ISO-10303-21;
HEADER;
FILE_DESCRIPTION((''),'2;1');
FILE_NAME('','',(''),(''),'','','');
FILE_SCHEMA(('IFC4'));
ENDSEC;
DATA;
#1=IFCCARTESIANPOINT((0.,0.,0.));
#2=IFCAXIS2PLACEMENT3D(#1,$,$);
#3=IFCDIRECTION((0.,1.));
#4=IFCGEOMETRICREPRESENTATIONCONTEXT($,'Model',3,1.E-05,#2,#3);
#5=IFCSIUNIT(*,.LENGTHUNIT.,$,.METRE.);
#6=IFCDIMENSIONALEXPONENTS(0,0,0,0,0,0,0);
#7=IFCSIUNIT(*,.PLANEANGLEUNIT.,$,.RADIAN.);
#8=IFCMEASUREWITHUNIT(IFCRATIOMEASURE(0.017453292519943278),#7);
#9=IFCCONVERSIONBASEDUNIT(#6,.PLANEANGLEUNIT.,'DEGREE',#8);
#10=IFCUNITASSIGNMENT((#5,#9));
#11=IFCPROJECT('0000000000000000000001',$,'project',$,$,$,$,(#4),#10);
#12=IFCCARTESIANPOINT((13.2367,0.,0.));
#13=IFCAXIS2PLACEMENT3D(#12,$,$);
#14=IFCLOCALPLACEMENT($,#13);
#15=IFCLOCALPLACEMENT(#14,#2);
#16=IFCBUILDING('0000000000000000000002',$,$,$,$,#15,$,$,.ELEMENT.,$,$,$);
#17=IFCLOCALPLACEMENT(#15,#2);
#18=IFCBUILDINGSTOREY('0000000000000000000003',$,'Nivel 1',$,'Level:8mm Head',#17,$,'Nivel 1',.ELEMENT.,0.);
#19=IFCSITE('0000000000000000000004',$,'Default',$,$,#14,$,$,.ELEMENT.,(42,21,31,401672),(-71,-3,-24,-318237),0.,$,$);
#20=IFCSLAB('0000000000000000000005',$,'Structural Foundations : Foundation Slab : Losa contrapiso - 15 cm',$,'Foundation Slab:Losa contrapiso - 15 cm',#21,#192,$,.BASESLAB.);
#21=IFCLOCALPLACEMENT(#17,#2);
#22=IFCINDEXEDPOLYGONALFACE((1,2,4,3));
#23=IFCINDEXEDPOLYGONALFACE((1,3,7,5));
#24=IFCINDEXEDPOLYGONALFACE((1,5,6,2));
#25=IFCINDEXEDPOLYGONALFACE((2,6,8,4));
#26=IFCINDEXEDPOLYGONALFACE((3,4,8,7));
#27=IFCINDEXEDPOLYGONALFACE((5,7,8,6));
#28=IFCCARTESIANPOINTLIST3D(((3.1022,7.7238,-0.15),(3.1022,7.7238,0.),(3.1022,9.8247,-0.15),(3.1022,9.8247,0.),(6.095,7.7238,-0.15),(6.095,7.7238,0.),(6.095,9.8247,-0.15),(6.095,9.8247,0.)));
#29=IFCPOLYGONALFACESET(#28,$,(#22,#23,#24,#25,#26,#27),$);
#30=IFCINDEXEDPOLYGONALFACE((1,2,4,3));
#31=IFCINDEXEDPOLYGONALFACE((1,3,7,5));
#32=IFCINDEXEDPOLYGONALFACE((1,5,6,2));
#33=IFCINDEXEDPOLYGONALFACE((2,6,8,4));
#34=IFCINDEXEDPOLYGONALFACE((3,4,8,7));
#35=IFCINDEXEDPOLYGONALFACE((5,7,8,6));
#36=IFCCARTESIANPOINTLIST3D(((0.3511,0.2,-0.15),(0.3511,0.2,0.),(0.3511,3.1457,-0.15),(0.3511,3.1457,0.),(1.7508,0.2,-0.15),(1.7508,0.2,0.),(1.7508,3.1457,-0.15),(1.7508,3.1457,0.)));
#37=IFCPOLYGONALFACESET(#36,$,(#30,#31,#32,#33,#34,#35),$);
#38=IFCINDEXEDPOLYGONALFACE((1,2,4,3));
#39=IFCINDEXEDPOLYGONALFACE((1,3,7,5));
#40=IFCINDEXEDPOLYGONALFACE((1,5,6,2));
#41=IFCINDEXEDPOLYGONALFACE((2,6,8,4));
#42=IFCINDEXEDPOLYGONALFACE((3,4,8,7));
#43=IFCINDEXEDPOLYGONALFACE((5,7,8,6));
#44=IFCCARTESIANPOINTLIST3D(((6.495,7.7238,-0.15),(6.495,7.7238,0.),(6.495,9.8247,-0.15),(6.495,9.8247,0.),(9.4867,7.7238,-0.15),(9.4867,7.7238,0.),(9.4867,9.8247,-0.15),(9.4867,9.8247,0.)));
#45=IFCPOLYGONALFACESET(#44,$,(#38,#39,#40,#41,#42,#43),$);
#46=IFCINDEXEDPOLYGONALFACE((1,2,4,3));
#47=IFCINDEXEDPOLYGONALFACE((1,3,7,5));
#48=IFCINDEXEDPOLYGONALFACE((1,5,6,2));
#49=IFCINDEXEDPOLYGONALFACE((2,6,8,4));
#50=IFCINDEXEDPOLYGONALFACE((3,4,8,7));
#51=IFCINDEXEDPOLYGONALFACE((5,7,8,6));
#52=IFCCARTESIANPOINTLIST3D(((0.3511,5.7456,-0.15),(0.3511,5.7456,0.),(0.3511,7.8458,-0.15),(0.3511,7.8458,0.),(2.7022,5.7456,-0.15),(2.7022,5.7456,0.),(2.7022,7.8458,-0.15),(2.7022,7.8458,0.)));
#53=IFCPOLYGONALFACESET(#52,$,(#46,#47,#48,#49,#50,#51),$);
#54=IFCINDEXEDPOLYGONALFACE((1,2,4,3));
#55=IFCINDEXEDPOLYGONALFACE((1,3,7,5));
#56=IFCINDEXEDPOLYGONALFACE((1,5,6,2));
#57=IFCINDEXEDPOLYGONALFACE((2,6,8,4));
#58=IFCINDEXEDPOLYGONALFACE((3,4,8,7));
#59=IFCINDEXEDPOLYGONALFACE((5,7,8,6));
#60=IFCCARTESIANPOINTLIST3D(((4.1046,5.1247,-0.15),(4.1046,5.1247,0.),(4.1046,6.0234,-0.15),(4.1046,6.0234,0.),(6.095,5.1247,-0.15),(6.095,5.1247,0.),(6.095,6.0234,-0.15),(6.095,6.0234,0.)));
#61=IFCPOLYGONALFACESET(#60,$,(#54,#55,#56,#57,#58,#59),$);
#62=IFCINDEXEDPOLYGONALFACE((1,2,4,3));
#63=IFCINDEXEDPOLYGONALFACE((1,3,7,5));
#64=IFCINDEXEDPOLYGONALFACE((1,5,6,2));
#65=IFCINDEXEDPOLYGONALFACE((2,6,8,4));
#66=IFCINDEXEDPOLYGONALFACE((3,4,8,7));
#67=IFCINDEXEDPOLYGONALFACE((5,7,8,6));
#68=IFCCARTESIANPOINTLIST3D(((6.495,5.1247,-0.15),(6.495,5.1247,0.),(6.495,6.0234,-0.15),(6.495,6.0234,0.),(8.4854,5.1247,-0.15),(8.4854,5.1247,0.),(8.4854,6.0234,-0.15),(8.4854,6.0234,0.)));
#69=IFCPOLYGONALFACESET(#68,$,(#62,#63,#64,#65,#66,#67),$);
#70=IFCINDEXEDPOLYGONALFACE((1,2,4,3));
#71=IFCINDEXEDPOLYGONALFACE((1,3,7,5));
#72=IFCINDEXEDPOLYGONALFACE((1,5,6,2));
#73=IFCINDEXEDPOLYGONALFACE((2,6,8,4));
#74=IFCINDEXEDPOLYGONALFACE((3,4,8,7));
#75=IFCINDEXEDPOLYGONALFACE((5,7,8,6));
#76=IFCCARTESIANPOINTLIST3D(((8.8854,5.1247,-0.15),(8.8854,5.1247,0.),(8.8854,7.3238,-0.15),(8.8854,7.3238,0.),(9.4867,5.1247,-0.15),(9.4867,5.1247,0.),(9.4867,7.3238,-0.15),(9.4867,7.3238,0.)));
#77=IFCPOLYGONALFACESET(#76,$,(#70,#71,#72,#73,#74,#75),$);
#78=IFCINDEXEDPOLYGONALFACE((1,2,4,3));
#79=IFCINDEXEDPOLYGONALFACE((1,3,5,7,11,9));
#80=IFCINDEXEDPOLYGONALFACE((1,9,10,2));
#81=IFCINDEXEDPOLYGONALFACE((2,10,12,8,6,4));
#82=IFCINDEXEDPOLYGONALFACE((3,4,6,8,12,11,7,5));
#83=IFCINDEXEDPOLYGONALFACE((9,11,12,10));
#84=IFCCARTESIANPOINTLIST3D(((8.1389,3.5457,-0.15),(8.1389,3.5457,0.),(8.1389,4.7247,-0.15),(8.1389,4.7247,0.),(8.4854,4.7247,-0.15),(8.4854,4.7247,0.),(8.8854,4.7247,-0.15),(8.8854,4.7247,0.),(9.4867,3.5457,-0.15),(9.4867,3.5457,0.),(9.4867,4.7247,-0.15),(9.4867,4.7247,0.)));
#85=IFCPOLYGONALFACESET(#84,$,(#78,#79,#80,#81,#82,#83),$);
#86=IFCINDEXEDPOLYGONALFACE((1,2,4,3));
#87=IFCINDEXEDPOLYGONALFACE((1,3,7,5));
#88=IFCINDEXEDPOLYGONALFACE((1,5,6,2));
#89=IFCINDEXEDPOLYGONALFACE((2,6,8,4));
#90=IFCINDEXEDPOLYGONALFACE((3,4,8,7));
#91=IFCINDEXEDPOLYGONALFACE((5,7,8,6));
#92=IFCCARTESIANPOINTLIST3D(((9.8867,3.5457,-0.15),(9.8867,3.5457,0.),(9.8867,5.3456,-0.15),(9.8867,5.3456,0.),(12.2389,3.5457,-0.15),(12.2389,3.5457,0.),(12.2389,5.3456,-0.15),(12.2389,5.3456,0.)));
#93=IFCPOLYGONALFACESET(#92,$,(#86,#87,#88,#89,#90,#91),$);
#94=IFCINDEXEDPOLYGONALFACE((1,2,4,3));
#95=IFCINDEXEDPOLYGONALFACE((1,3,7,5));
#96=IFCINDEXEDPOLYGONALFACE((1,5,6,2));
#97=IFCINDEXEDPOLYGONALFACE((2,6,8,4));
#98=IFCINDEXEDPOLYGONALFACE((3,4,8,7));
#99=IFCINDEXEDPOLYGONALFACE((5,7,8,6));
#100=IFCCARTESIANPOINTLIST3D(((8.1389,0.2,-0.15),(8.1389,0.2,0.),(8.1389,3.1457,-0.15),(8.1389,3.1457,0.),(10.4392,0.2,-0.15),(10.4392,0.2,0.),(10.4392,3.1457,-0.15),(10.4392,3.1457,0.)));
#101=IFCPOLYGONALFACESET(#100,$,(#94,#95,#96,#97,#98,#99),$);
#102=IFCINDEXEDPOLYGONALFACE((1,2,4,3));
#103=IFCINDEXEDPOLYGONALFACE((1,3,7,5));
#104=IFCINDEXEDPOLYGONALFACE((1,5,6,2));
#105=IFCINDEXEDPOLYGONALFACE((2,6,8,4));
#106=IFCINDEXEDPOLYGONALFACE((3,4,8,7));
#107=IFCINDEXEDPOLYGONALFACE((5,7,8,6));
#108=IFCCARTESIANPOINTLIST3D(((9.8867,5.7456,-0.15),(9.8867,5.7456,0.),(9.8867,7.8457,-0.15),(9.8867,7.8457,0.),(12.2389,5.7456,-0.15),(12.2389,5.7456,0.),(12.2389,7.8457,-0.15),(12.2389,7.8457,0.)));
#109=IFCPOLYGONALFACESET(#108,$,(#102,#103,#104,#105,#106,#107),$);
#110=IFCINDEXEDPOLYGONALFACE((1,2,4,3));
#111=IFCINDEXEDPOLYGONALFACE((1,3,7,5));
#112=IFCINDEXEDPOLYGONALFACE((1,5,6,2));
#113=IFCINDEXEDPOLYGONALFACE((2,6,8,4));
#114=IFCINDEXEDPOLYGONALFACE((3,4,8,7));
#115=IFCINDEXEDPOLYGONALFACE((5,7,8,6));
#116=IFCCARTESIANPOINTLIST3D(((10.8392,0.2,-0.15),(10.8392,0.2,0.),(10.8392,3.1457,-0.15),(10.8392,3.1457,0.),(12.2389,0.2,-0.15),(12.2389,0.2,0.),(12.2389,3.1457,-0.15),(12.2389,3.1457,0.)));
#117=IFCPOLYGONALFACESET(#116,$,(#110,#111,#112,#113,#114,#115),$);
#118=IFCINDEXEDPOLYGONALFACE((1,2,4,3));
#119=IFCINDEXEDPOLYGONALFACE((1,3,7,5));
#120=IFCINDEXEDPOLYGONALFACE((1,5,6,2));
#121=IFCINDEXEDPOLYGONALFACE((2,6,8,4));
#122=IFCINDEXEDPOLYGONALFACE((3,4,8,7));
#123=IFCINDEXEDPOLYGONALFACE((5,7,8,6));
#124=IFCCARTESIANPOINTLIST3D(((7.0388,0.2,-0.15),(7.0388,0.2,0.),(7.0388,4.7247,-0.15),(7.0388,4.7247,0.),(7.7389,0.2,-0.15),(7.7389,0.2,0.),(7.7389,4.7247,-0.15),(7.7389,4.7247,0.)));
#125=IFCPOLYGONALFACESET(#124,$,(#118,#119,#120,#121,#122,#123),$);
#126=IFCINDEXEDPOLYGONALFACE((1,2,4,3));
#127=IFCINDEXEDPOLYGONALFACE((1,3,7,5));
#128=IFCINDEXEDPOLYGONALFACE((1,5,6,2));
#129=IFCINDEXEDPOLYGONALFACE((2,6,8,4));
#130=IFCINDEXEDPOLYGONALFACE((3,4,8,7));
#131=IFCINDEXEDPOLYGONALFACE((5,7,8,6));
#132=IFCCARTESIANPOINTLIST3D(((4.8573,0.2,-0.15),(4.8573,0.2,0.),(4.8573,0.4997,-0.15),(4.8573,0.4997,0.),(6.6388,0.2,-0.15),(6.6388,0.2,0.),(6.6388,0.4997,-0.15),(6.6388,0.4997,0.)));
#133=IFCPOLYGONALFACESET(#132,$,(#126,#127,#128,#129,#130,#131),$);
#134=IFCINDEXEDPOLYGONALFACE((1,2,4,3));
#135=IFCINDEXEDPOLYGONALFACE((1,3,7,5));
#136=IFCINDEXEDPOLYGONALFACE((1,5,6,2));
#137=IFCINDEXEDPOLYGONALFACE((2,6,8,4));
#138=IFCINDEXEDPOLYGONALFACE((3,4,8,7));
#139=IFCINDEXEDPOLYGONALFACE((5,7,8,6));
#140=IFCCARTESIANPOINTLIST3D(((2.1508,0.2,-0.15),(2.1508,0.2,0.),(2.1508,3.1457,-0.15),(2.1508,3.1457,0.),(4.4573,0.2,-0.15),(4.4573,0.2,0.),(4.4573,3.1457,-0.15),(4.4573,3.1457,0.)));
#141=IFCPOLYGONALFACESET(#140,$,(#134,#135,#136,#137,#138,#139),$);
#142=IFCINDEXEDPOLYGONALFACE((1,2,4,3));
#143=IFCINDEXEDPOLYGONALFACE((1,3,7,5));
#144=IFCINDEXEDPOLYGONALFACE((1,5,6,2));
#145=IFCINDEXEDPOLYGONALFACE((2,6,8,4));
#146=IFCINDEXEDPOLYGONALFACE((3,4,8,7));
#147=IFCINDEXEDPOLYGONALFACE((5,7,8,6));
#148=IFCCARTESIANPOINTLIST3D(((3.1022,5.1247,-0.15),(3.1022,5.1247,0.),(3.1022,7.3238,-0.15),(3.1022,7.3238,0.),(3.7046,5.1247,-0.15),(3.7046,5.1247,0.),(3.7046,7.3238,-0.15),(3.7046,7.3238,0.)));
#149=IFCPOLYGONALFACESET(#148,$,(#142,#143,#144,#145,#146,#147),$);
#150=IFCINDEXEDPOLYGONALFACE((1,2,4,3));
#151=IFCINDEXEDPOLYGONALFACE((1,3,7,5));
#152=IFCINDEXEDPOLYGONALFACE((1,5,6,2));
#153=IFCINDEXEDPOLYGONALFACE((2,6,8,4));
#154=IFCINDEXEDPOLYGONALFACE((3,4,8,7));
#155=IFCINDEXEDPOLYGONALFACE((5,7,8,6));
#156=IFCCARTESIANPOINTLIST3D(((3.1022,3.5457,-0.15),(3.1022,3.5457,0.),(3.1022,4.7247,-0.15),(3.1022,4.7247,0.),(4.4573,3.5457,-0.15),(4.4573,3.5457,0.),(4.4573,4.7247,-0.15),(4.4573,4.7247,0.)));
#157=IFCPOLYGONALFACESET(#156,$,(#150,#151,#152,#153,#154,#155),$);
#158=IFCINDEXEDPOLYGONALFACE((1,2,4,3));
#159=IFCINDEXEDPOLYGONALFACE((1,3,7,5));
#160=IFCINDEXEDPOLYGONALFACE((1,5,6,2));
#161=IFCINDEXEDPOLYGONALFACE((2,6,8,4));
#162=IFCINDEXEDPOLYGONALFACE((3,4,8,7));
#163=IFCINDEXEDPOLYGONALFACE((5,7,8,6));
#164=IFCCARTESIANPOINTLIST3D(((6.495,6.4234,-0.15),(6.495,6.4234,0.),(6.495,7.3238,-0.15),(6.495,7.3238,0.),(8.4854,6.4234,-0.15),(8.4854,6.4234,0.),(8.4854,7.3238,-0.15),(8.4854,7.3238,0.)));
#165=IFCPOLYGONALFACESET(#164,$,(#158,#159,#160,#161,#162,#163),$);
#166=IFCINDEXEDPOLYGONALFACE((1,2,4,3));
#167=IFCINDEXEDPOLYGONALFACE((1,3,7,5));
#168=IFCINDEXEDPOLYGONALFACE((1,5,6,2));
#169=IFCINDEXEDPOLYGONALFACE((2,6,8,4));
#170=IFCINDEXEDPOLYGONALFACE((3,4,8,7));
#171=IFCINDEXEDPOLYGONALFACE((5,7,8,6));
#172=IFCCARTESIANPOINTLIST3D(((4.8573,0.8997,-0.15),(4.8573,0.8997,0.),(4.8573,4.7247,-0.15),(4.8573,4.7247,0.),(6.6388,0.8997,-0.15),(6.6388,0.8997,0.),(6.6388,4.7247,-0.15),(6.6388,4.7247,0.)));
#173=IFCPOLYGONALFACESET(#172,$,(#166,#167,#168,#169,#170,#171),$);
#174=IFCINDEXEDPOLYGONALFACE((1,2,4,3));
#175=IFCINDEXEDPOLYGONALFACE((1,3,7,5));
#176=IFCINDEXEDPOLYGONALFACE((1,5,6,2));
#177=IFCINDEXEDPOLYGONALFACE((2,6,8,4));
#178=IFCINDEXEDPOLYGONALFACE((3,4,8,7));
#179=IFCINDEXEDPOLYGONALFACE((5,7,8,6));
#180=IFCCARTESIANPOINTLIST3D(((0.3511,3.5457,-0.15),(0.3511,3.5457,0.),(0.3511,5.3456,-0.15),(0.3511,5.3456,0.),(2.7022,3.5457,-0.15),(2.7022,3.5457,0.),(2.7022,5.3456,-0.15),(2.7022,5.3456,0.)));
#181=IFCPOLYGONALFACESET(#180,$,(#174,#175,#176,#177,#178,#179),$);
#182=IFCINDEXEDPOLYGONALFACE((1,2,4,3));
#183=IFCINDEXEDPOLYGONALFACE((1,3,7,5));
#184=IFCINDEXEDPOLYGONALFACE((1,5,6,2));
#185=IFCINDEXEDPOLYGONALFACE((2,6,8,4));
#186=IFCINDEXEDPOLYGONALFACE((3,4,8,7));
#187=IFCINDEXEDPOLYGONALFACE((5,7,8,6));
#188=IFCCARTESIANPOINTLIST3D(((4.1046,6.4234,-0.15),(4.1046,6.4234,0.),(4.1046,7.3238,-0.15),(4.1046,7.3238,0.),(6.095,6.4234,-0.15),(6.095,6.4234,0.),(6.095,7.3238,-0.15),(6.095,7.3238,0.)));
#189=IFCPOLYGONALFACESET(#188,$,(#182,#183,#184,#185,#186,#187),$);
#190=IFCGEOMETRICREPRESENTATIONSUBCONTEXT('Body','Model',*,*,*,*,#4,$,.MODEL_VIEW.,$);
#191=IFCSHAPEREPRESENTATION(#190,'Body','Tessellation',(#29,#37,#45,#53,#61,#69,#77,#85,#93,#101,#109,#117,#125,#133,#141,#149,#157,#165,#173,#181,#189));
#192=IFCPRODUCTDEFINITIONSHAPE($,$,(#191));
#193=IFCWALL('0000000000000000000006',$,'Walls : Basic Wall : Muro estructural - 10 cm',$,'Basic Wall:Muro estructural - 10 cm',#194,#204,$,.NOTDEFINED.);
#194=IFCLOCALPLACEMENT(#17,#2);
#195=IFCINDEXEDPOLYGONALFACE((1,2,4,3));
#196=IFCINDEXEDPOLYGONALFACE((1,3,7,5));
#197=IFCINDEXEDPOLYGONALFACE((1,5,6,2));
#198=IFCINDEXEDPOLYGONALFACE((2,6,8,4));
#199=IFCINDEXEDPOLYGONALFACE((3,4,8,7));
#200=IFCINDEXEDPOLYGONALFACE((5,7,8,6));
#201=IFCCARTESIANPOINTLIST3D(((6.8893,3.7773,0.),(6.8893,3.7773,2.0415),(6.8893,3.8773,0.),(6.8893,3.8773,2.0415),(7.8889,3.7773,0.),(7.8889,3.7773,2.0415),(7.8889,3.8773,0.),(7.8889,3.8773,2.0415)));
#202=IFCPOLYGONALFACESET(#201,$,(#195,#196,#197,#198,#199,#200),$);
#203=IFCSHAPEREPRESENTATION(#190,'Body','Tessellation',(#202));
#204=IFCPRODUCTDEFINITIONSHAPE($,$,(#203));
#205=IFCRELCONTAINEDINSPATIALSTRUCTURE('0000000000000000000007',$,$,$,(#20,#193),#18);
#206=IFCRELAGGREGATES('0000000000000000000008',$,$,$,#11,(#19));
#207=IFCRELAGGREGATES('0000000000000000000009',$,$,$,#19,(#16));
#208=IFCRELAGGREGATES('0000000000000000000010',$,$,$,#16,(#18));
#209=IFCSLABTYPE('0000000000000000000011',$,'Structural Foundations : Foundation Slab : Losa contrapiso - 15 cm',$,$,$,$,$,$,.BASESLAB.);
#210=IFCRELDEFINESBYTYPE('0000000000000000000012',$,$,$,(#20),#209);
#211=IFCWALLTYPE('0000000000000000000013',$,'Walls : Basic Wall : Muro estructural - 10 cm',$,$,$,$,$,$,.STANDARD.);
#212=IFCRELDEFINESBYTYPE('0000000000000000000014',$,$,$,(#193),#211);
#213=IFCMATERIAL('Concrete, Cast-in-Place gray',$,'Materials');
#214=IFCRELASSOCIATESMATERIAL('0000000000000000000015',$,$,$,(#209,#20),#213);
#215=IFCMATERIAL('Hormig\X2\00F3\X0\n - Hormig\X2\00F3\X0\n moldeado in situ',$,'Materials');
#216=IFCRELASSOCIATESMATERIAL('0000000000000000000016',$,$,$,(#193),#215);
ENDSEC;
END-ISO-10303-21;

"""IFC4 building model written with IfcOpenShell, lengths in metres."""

from ifc_helpers import new_model, entity, si_unit, converted_unit, direction, frame, origin, place, context, subcontext, project, spatial, indexed_curve, outline, extrude, material, type_object, element, save


model = new_model("IFC4")

# Units and contexts
model_context = context("Model", 3, precision=1e-05, world=origin(), true_north=direction((0.0, 1.0)))
body_context = subcontext(model_context, "Body", "Model", "MODEL_VIEW")
ifc_project = project(units=[si_unit("LENGTHUNIT", "METRE"), converted_unit("PLANEANGLEUNIT", "DEGREE", entity("IfcRatioMeasure", 0.017453292519943278), si_unit("PLANEANGLEUNIT", "RADIAN"), dimensions=[0, 0, 0, 0, 0, 0, 0])], contexts=[model_context])

# Site, building, storey
site_placement = place(None, frame((13.2367, 0.0, 0.0)))
site = spatial("IfcSite", under=ifc_project, at=site_placement, Name="Default", CompositionType="ELEMENT", RefLatitude=(42, 21, 31, 401672), RefLongitude=(-71, -3, -24, -318237), RefElevation=0.0)
building_placement = place(site_placement, origin())
building = spatial("IfcBuilding", under=site, at=building_placement, CompositionType="ELEMENT")
storey_placement = place(building_placement, origin())
storey = spatial("IfcBuildingStorey", under=building, at=storey_placement, Name="Nivel 1", ObjectType="Level:8mm Head", LongName="Nivel 1", CompositionType="ELEMENT", Elevation=0.0)

# Slab
ifc_material_1 = material(Name="Concrete, Cast-in-Place gray", Category="Materials")
slab_type = type_object("IfcSlabType", Name="Structural Foundations : Foundation Slab : Losa contrapiso - 15 cm", PredefinedType="BASESLAB", material=ifc_material_1)
slab_placement = place(storey_placement, origin())
element("IfcSlab", 1, at=slab_placement, inside=storey, type_object=slab_type, material=ifc_material_1, Name="Structural Foundations : Foundation Slab : Losa contrapiso - 15 cm", ObjectType="Foundation Slab:Losa contrapiso - 15 cm", PredefinedType="BASESLAB", context=body_context, shape_type="SweptSolid", body=[
    extrude(outline(indexed_curve([(-1.0505, -1.4964), (1.0505, -1.4964), (1.0505, 1.4964), (-1.0505, 1.4964), (-1.0505, -1.4964)], self_intersect=False)), frame((4.5986, 8.7743, -0.15), z_axis=(0.0, 0.0, 1.0), x_axis=(0.0, -1.0, 0.0)), (0.0, 0.0, 1.0), 0.15),
    extrude(outline(indexed_curve([(-0.6998, -1.4729), (0.6998, -1.4729), (0.6998, 1.4729), (-0.6998, 1.4729), (-0.6998, -1.4729)], self_intersect=False)), frame((1.051, 1.6729, -0.15), z_axis=(0.0, 0.0, 1.0), x_axis=(-1.0, 0.0, 0.0)), (0.0, 0.0, 1.0), 0.15),
    extrude(outline(indexed_curve([(-1.4958, -1.0505), (1.4958, -1.0505), (1.4958, 1.0505), (-1.4958, 1.0505), (-1.4958, -1.0505)], self_intersect=False)), frame((7.9908, 8.7743, -0.15)), (0.0, 0.0, 1.0), 0.15),
    extrude(outline(indexed_curve([(-1.1755, -1.0501), (1.1755, -1.0501), (1.1755, 1.0501), (-1.1755, 1.0501), (-1.1755, -1.0501)], self_intersect=False)), frame((1.5266, 6.7957, -0.15), z_axis=(0.0, 0.0, 1.0), x_axis=(-1.0, 0.0, 0.0)), (0.0, 0.0, 1.0), 0.15),
    extrude(outline(indexed_curve([(-0.4493, -0.9952), (0.4493, -0.9952), (0.4493, 0.9952), (-0.4493, 0.9952), (-0.4493, -0.9952)], self_intersect=False)), frame((5.0998, 5.574, -0.15), z_axis=(0.0, 0.0, 1.0), x_axis=(0.0, 1.0, 0.0)), (0.0, 0.0, 1.0), 0.15),
    extrude(outline(indexed_curve([(-0.9952, -0.4493), (0.9952, -0.4493), (0.9952, 0.4493), (-0.9952, 0.4493), (-0.9952, -0.4493)], self_intersect=False)), frame((7.4902, 5.574, -0.15)), (0.0, 0.0, 1.0), 0.15),
    extrude(outline(indexed_curve([(-0.3007, -1.0996), (0.3007, -1.0996), (0.3007, 1.0996), (-0.3007, 1.0996), (-0.3007, -1.0996)], self_intersect=False)), frame((9.186, 6.2242, -0.15), z_axis=(0.0, 0.0, 1.0), x_axis=(-1.0, 0.0, 0.0)), (0.0, 0.0, 1.0), 0.15),
    extrude(outline(indexed_curve([(-0.786, -0.7164), (0.393, -0.7164), (0.393, -0.1151), (0.393, 0.2849), (0.393, 0.6314), (-0.786, 0.6314), (-0.786, -0.7164)], self_intersect=False)), frame((8.7703, 4.3317, -0.15), z_axis=(0.0, 0.0, 1.0), x_axis=(0.0, 1.0, 0.0)), (0.0, 0.0, 1.0), 0.15),
    extrude(outline(indexed_curve([(-0.8999, -1.1761), (0.8999, -1.1761), (0.8999, 1.1761), (-0.8999, 1.1761), (-0.8999, -1.1761)], self_intersect=False)), frame((11.0628, 4.4456, -0.15), z_axis=(0.0, 0.0, 1.0), x_axis=(0.0, -1.0, 0.0)), (0.0, 0.0, 1.0), 0.15),
    extrude(outline(indexed_curve([(-1.4729, -1.1502), (1.4729, -1.1502), (1.4729, 1.1502), (-1.4729, 1.1502), (-1.4729, -1.1502)], self_intersect=False)), frame((9.289, 1.6729, -0.15), z_axis=(0.0, 0.0, 1.0), x_axis=(0.0, -1.0, 0.0)), (0.0, 0.0, 1.0), 0.15),
    extrude(outline(indexed_curve([(-1.05, -1.1761), (1.05, -1.1761), (1.05, 1.1761), (-1.05, 1.1761), (-1.05, -1.1761)], self_intersect=False)), frame((11.0628, 6.7956, -0.15), z_axis=(0.0, 0.0, 1.0), x_axis=(0.0, -1.0, 0.0)), (0.0, 0.0, 1.0), 0.15),
    extrude(outline(indexed_curve([(-1.4729, -0.6998), (1.4729, -0.6998), (1.4729, 0.6998), (-1.4729, 0.6998), (-1.4729, -0.6998)], self_intersect=False)), frame((11.539, 1.6729, -0.15), z_axis=(0.0, 0.0, 1.0), x_axis=(0.0, -1.0, 0.0)), (0.0, 0.0, 1.0), 0.15),
    extrude(outline(indexed_curve([(-2.2623, -0.35), (2.2623, -0.35), (2.2623, 0.35), (-2.2623, 0.35), (-2.2623, -0.35)], self_intersect=False)), frame((7.3889, 2.4623, -0.15), z_axis=(0.0, 0.0, 1.0), x_axis=(0.0, -1.0, 0.0)), (0.0, 0.0, 1.0), 0.15),
    extrude(outline(indexed_curve([(-0.1498, -0.8908), (0.1498, -0.8908), (0.1498, 0.8908), (-0.1498, 0.8908), (-0.1498, -0.8908)], self_intersect=False)), frame((5.748, 0.3498, -0.15), z_axis=(0.0, 0.0, 1.0), x_axis=(0.0, -1.0, 0.0)), (0.0, 0.0, 1.0), 0.15),
    extrude(outline(indexed_curve([(-1.4729, -1.1532), (1.4729, -1.1532), (1.4729, 1.1532), (-1.4729, 1.1532), (-1.4729, -1.1532)], self_intersect=False)), frame((3.304, 1.6729, -0.15), z_axis=(0.0, 0.0, 1.0), x_axis=(0.0, -1.0, 0.0)), (0.0, 0.0, 1.0), 0.15),
    extrude(outline(indexed_curve([(-1.0996, -0.3012), (1.0996, -0.3012), (1.0996, 0.3012), (-1.0996, 0.3012), (-1.0996, -0.3012)], self_intersect=False)), frame((3.4034, 6.2242, -0.15), z_axis=(0.0, 0.0, 1.0), x_axis=(0.0, -1.0, 0.0)), (0.0, 0.0, 1.0), 0.15),
    extrude(outline(indexed_curve([(-0.5895, -0.6776), (0.5895, -0.6776), (0.5895, 0.6776), (-0.5895, 0.6776), (-0.5895, -0.6776)], self_intersect=False)), frame((3.7797, 4.1352, -0.15), z_axis=(0.0, 0.0, 1.0), x_axis=(0.0, 1.0, 0.0)), (0.0, 0.0, 1.0), 0.15),
    extrude(outline(indexed_curve([(-0.9952, -0.4502), (0.9952, -0.4502), (0.9952, 0.4502), (-0.9952, 0.4502), (-0.9952, -0.4502)], self_intersect=False)), frame((7.4902, 6.8736, -0.15)), (0.0, 0.0, 1.0), 0.15),
    extrude(outline(indexed_curve([(-1.9125, -0.8908), (1.9125, -0.8908), (1.9125, 0.8908), (-1.9125, 0.8908), (-1.9125, -0.8908)], self_intersect=False)), frame((5.748, 2.8122, -0.15), z_axis=(0.0, 0.0, 1.0), x_axis=(0.0, -1.0, 0.0)), (0.0, 0.0, 1.0), 0.15),
    extrude(outline(indexed_curve([(-1.1755, -0.8999), (1.1755, -0.8999), (1.1755, 0.8999), (-1.1755, 0.8999), (-1.1755, -0.8999)], self_intersect=False)), frame((1.5266, 4.4456, -0.15), z_axis=(0.0, 0.0, 1.0), x_axis=(-1.0, 0.0, 0.0)), (0.0, 0.0, 1.0), 0.15),
    extrude(outline(indexed_curve([(-0.4502, -0.9952), (0.4502, -0.9952), (0.4502, 0.9952), (-0.4502, 0.9952), (-0.4502, -0.9952)], self_intersect=False)), frame((5.0998, 6.8736, -0.15), z_axis=(0.0, 0.0, 1.0), x_axis=(0.0, -1.0, 0.0)), (0.0, 0.0, 1.0), 0.15),
])

# Wall
ifc_material_2 = material(Name="Hormigón - Hormigón moldeado in situ", Category="Materials")
wall_type_1 = type_object("IfcWallType", Name="Walls : Basic Wall : Muro estructural - 10 cm", PredefinedType="STANDARD")
wall_1_placement = place(storey_placement, frame((6.8893, 3.8273, 0.0)))
element("IfcWall", 2, at=wall_1_placement, inside=storey, type_object=wall_type_1, material=ifc_material_2, Name="Walls : Basic Wall : Muro estructural - 10 cm", ObjectType="Basic Wall:Muro estructural - 10 cm", PredefinedType="NOTDEFINED", context=body_context, shape_type="SweptSolid", body=[
    extrude(outline(indexed_curve([(0.9996, 0.05), (0.0, 0.05), (0.0, -0.05), (0.9996, -0.05), (0.9996, 0.05)], self_intersect=False)), origin(), (0.0, 0.0, 1.0), 2.0415),
])

save(model, "model.ifc")
